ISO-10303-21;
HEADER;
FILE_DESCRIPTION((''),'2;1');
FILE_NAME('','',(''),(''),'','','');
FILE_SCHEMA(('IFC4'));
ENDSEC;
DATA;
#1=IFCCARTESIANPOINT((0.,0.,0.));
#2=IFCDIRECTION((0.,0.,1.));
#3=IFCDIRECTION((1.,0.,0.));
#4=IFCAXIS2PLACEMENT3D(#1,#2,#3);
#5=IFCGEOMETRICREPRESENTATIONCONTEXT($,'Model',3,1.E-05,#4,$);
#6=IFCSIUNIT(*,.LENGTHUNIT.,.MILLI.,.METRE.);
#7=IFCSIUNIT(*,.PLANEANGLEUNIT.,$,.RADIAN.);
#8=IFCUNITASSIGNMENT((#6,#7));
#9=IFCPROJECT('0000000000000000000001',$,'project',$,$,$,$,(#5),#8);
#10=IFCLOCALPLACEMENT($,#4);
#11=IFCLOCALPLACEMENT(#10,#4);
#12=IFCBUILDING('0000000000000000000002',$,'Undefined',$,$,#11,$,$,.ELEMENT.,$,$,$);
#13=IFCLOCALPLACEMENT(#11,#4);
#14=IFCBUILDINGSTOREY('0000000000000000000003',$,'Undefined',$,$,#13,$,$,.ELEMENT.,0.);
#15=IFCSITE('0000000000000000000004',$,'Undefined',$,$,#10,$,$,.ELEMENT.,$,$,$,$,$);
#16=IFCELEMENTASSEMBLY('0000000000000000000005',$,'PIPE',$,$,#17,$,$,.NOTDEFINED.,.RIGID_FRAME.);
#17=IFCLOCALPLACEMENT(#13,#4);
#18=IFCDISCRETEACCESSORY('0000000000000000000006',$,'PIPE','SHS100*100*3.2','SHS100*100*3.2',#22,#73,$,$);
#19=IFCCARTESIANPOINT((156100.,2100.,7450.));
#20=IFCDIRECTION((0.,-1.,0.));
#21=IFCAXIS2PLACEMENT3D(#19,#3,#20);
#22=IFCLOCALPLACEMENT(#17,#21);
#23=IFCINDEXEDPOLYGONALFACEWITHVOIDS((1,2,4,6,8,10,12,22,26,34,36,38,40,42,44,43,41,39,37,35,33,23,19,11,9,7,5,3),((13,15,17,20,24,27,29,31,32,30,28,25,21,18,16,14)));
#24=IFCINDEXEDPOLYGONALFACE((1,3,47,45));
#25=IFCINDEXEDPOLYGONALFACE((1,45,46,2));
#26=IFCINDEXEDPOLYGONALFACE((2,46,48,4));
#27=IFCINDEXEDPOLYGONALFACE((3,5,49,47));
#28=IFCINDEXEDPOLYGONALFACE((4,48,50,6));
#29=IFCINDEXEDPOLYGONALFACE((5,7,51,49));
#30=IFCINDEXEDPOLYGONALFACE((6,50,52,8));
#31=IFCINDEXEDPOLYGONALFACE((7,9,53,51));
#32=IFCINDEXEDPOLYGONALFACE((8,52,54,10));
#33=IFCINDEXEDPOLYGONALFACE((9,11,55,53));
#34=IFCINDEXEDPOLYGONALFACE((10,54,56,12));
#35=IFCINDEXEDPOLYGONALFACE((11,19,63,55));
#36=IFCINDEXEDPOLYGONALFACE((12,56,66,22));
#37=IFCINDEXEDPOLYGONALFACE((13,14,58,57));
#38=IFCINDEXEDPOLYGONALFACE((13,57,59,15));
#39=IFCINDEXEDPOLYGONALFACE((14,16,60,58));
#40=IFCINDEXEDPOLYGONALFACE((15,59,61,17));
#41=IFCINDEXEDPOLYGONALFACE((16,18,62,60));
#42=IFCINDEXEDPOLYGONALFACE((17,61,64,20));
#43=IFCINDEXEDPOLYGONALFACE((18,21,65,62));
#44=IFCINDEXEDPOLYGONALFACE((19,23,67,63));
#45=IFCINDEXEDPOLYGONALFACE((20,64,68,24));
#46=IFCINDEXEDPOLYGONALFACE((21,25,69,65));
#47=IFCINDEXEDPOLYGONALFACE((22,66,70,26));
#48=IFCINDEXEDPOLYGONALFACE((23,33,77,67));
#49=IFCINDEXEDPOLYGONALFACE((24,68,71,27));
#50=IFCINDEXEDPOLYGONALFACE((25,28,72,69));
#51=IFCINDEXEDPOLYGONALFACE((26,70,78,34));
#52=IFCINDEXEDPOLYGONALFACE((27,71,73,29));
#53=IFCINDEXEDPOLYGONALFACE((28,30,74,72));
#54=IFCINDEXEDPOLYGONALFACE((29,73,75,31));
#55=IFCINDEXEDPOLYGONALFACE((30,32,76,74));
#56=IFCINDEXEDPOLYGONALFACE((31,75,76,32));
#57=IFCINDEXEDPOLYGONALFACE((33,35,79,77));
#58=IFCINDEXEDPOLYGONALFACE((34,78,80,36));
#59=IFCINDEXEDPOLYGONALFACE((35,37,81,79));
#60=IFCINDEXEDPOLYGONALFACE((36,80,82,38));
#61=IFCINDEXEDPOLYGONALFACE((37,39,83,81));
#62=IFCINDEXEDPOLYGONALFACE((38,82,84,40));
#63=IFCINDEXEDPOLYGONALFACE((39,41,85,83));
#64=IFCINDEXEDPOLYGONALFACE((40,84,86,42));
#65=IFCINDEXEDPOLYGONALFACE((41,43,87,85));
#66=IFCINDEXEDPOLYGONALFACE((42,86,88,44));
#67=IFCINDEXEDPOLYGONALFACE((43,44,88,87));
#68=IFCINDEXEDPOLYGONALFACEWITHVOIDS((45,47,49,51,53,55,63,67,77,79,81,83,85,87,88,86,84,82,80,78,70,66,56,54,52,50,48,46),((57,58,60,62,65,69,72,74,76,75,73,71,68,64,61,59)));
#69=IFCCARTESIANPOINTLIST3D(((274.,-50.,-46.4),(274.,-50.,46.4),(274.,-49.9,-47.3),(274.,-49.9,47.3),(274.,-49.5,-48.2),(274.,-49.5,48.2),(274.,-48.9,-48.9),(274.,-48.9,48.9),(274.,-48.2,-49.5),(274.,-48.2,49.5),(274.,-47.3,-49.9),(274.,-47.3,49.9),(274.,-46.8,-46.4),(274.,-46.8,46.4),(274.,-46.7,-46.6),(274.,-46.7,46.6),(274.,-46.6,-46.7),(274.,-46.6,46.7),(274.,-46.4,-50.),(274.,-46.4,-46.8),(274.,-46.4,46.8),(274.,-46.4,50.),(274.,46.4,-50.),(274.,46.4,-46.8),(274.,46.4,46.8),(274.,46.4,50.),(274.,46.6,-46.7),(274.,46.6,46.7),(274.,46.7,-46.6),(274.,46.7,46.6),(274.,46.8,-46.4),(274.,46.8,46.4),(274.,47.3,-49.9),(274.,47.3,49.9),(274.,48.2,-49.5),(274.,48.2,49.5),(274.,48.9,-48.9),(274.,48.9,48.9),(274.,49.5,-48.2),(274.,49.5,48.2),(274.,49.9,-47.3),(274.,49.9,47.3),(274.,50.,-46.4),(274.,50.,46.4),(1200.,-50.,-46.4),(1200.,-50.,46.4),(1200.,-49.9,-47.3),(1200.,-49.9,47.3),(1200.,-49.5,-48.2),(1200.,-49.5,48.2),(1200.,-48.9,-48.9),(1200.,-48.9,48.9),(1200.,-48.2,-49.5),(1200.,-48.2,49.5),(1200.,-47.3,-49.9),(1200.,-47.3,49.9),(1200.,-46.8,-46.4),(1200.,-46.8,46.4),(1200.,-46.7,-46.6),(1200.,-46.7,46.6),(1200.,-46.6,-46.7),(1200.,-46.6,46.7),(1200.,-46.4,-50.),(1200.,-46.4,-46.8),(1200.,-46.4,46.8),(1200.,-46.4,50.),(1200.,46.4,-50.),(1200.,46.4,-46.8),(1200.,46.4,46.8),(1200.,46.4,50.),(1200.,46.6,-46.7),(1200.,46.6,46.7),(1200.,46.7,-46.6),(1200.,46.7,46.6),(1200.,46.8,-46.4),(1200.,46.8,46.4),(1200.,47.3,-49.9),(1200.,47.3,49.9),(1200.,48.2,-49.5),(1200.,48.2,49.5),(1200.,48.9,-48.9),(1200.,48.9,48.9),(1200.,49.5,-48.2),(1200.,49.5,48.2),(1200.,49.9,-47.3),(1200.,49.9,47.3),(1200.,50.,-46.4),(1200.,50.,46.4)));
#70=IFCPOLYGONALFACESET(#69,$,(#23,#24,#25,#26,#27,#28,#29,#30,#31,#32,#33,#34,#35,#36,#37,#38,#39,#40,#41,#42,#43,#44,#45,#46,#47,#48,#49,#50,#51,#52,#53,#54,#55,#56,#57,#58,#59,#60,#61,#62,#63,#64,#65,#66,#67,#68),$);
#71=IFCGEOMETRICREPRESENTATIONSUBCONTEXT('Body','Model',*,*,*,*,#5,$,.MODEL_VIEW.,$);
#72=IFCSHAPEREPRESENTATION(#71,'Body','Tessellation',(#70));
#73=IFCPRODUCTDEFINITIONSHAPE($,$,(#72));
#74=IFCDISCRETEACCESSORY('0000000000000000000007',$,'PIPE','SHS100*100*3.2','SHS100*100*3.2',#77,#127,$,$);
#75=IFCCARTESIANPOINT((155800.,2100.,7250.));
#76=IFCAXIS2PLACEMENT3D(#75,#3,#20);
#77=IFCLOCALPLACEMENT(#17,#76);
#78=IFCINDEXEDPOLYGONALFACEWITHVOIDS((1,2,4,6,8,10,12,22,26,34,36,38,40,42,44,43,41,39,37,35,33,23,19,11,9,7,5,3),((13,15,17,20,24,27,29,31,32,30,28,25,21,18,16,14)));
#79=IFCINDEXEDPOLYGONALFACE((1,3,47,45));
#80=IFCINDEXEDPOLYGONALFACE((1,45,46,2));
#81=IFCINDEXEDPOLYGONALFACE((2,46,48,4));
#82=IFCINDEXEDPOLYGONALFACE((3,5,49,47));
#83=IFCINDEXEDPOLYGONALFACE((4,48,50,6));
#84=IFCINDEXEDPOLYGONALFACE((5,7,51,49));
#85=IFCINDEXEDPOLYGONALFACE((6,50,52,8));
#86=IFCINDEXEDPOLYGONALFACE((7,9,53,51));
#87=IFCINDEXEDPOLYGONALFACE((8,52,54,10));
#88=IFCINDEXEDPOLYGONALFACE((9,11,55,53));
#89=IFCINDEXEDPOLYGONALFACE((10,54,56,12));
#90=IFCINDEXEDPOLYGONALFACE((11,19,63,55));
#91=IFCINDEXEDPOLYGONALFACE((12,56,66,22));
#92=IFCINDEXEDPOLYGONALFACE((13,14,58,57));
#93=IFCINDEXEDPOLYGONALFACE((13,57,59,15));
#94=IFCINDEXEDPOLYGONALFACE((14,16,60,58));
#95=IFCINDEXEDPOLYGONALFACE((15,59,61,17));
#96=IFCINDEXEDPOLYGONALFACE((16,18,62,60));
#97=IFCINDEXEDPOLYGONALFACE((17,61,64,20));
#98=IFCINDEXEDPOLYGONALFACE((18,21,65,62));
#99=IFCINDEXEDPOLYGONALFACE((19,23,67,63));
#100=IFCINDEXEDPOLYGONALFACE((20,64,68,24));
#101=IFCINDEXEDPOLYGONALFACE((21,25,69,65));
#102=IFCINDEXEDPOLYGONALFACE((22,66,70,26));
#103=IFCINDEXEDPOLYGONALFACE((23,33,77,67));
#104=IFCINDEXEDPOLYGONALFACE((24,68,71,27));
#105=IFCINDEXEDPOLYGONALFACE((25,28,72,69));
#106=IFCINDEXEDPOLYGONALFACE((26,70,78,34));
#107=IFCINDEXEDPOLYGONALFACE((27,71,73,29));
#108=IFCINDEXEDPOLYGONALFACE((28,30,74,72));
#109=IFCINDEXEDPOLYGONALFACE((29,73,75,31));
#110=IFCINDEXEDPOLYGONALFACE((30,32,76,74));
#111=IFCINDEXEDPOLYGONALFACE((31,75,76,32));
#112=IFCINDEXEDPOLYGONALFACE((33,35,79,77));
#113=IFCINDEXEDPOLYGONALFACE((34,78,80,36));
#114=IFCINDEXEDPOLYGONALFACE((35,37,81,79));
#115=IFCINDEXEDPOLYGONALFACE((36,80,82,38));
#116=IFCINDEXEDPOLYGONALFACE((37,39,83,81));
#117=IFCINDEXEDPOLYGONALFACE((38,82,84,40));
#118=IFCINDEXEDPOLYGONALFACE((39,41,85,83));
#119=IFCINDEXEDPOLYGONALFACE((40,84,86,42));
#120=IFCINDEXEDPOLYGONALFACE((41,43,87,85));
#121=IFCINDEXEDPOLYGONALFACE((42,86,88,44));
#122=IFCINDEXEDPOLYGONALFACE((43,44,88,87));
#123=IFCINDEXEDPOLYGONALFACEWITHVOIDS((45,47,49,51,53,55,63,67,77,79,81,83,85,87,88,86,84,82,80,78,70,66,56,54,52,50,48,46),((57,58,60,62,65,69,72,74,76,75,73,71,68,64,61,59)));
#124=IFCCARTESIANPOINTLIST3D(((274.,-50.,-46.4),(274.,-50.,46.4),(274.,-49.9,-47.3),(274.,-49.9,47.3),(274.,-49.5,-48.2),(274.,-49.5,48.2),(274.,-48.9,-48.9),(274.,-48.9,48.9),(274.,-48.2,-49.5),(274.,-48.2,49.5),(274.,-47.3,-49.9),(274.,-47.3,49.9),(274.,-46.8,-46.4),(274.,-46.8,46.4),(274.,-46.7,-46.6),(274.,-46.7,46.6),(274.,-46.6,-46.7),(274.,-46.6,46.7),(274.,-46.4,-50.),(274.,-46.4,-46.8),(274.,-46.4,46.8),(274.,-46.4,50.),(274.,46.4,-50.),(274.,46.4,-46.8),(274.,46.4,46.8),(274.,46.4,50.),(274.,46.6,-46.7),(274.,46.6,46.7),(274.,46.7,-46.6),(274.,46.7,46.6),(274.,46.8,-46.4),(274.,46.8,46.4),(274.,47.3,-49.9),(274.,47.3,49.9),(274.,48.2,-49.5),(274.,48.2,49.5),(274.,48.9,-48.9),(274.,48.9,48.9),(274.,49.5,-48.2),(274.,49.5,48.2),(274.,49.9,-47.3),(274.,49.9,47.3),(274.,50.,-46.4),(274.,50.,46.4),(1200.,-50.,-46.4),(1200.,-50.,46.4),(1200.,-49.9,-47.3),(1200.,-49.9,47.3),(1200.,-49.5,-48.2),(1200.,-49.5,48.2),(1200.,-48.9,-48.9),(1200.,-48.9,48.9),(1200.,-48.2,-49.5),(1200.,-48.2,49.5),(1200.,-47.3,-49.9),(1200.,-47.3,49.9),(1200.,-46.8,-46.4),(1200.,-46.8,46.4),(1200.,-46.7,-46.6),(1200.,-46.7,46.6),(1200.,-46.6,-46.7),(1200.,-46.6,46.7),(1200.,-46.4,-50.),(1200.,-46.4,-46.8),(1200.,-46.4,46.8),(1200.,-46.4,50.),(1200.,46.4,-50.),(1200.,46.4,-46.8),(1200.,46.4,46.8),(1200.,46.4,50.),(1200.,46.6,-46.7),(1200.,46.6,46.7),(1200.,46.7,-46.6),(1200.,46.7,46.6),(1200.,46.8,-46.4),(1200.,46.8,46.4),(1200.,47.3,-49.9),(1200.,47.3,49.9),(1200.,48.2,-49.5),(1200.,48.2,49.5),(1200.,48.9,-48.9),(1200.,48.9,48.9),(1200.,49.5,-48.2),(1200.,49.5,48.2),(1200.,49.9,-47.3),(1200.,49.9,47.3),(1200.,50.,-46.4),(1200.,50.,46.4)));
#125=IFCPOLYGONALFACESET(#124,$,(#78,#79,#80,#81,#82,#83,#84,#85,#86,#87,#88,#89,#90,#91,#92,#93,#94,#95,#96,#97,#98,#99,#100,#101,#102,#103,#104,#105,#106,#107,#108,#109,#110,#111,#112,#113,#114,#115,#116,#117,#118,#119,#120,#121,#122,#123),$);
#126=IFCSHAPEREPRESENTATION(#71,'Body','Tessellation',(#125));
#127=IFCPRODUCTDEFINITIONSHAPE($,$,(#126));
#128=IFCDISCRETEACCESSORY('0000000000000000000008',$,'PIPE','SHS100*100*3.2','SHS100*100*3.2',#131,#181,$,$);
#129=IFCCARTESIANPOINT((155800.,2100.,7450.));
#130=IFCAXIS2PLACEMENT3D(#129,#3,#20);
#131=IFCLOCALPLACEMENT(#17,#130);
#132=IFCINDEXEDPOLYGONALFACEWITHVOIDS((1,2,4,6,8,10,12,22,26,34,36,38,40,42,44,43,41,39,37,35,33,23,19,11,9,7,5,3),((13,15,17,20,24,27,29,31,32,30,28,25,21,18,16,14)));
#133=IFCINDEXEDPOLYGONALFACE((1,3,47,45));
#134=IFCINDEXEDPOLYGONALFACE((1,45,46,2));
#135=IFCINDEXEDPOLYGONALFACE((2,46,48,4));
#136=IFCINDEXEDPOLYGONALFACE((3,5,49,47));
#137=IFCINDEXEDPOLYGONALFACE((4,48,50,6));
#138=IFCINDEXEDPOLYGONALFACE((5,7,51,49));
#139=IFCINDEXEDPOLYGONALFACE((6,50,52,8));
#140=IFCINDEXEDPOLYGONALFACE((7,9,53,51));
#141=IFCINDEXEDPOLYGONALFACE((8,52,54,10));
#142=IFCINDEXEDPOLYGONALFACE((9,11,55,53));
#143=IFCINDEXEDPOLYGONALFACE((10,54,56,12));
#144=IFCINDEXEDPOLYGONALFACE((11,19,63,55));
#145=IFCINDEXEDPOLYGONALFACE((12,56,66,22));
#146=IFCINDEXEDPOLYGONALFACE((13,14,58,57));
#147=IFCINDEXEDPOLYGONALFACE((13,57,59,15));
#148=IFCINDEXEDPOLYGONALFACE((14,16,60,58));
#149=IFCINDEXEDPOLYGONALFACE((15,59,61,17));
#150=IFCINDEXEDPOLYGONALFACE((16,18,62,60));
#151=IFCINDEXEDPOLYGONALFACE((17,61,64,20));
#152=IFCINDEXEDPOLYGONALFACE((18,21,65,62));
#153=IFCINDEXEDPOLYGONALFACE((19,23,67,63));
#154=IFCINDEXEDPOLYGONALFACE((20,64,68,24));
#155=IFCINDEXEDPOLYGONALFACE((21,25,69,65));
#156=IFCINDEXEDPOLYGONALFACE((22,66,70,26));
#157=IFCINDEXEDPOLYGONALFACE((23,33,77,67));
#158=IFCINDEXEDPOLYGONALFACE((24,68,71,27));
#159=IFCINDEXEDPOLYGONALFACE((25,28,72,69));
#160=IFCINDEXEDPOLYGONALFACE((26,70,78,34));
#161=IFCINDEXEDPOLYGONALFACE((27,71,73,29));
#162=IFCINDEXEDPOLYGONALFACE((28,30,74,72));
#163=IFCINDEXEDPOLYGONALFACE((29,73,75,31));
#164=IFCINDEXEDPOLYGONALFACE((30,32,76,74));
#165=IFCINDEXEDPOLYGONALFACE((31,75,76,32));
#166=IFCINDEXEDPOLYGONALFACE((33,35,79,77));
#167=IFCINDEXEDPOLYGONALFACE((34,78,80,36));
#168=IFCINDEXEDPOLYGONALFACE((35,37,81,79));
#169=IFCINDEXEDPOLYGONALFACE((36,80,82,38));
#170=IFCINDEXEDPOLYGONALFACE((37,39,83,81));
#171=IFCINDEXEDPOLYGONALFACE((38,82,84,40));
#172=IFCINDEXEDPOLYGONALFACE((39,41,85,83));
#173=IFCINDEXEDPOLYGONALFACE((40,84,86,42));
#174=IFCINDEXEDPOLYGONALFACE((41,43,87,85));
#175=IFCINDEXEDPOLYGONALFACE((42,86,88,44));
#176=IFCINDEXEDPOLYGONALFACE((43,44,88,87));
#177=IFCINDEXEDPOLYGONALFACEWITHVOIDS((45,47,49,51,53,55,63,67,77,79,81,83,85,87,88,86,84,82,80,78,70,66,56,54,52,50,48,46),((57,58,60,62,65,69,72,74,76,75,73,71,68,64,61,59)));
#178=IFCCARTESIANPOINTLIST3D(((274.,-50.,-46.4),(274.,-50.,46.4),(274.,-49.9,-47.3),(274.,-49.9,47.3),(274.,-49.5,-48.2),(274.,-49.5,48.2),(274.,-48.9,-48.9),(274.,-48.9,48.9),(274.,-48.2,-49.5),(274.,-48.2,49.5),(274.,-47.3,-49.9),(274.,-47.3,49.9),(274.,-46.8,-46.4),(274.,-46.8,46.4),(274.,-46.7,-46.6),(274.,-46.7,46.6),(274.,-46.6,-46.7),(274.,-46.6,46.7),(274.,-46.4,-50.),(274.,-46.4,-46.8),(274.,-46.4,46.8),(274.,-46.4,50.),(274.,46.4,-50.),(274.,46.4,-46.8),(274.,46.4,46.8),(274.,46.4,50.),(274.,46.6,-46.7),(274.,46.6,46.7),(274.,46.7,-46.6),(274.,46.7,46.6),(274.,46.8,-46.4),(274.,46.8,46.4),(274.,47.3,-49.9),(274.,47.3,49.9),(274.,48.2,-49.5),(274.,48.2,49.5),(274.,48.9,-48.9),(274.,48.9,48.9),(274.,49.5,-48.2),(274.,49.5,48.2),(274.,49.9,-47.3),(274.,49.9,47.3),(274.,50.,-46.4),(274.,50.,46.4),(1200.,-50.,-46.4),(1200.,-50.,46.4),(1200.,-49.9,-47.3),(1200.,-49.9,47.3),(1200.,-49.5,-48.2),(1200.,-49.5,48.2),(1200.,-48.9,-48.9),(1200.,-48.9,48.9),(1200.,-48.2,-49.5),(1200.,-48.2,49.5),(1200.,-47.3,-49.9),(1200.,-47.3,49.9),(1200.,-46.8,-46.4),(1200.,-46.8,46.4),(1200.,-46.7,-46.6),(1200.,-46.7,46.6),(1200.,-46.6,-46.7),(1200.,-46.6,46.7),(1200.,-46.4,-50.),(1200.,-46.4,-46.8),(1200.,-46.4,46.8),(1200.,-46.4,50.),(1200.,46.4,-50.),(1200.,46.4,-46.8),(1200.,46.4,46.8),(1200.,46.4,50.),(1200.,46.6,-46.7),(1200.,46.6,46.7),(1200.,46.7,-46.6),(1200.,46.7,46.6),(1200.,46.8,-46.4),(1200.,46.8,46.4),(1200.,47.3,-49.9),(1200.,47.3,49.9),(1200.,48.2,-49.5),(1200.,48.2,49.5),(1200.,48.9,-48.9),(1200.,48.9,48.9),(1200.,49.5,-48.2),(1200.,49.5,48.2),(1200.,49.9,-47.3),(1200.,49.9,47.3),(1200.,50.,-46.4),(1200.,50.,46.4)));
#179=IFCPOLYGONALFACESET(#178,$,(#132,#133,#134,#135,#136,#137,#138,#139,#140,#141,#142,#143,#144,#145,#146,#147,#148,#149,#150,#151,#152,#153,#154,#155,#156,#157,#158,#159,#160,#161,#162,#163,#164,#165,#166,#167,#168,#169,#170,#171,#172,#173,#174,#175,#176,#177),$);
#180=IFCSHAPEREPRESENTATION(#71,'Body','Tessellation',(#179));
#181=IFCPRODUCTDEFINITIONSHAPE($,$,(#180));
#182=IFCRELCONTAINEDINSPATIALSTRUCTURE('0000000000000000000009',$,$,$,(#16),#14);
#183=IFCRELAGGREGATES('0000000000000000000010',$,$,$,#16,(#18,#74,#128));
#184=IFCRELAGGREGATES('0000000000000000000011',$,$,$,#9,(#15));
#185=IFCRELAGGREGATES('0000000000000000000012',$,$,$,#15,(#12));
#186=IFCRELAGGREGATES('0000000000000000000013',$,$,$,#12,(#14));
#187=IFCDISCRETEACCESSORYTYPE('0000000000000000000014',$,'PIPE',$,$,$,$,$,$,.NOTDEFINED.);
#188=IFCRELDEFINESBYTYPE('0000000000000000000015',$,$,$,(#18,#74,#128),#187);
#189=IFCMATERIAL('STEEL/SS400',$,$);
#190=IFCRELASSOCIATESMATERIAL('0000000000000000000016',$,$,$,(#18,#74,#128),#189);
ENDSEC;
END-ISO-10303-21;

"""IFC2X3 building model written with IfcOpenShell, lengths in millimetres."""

from ifc_helpers import new_model, si_unit, frame, origin_with_axes, origin_2d_with_axis, place, context, subcontext, project, spatial, hollow_rectangle, extrude, clip, halfspace, material, type_object, element, aggregate, save


model = new_model("IFC2X3")

# Units and contexts
model_context = context("Model", 3, precision=1e-05, world=origin_with_axes())
body_context = subcontext(model_context, "Body", "Model", "MODEL_VIEW")
ifc_project = project(units=[si_unit("LENGTHUNIT", "METRE", prefix="MILLI"), si_unit("PLANEANGLEUNIT", "RADIAN")], contexts=[model_context])

# Site, building, storey
site_placement = place(None, origin_with_axes())
site = spatial("IfcSite", under=ifc_project, at=site_placement, Name="Undefined", CompositionType="ELEMENT")
building_placement = place(site_placement, origin_with_axes())
building = spatial("IfcBuilding", under=site, at=building_placement, Name="Undefined", CompositionType="ELEMENT")
storey_placement = place(building_placement, origin_with_axes())
storey = spatial("IfcBuildingStorey", under=building, at=storey_placement, Name="Undefined", CompositionType="ELEMENT", Elevation=0.0)

# Shared definitions
ifc_material_1 = material(Name="STEEL/SS400")

# Shared definitions
discrete_accessory_type_1 = type_object("IfcDiscreteAccessoryType", Name="PIPE")

# Element assembly, discrete accessories
assembly_1_placement = place(storey_placement, origin_with_axes())
assembly_1 = element("IfcElementAssembly", 1, at=assembly_1_placement, inside=storey, Name="PIPE", AssemblyPlace="NOTDEFINED", PredefinedType="RIGID_FRAME")
discrete_accessory_1_placement = place(assembly_1_placement, frame((156100.0, 2100.0, 7450.0), z_axis=(1.0, 0.0, 0.0), x_axis=(0.0, -1.0, 0.0)))
discrete_accessory_1 = element("IfcDiscreteAccessory", 2, at=discrete_accessory_1_placement, type_object=discrete_accessory_type_1, material=ifc_material_1, Name="PIPE", Description="SHS100*100*3.2", ObjectType="SHS100*100*3.2", context=body_context, shape_type="Clipping", body=[
    clip(clip(extrude(hollow_rectangle(XDim=100.0, YDim=100.0, WallThickness=3.2, InnerFilletRadius=0.4, OuterFilletRadius=3.6, at=origin_2d_with_axis()), frame((1200.0, 0.0, 0.0), z_axis=(-1.0, 0.0, 0.0), x_axis=(0.0, -1.0, 0.0)), (0.0, 0.0, 1.0), 1200.0), halfspace(frame((274.0, 50.0, -50.0), z_axis=(-1.0, 0.0, 0.0), x_axis=(0.0, 0.0, 1.0)), False)), halfspace(frame((1200.0, 0.0, -50.0), z_axis=(-1.0, 0.0, 0.0), x_axis=(0.0, 1.0, 0.0)), True)),
])
discrete_accessory_2_placement = place(assembly_1_placement, frame((155800.0, 2100.0, 7250.0), z_axis=(1.0, 0.0, 0.0), x_axis=(0.0, -1.0, 0.0)))
discrete_accessory_2 = element("IfcDiscreteAccessory", 3, at=discrete_accessory_2_placement, type_object=discrete_accessory_type_1, material=ifc_material_1, Name="PIPE", Description="SHS100*100*3.2", ObjectType="SHS100*100*3.2", context=body_context, shape_type="Clipping", body=[
    clip(clip(extrude(hollow_rectangle(XDim=100.0, YDim=100.0, WallThickness=3.2, InnerFilletRadius=0.4, OuterFilletRadius=3.6, at=origin_2d_with_axis()), frame((1200.0, 0.0, 0.0), z_axis=(-1.0, 0.0, 0.0), x_axis=(0.0, -1.0, 0.0)), (0.0, 0.0, 1.0), 1200.0), halfspace(frame((274.0, 50.0, -50.0), z_axis=(-1.0, 0.0, 0.0), x_axis=(0.0, 0.0, 1.0)), False)), halfspace(frame((1200.0, 0.0, -50.0), z_axis=(-1.0, 0.0, 0.0), x_axis=(0.0, 1.0, 0.0)), True)),
])
discrete_accessory_3_placement = place(assembly_1_placement, frame((155800.0, 2100.0, 7450.0), z_axis=(1.0, 0.0, 0.0), x_axis=(0.0, -1.0, 0.0)))
discrete_accessory_3 = element("IfcDiscreteAccessory", 4, at=discrete_accessory_3_placement, type_object=discrete_accessory_type_1, material=ifc_material_1, Name="PIPE", Description="SHS100*100*3.2", ObjectType="SHS100*100*3.2", context=body_context, shape_type="Clipping", body=[
    clip(clip(extrude(hollow_rectangle(XDim=100.0, YDim=100.0, WallThickness=3.2, InnerFilletRadius=0.4, OuterFilletRadius=3.6, at=origin_2d_with_axis()), frame((1200.0, 0.0, 0.0), z_axis=(-1.0, 0.0, 0.0), x_axis=(0.0, -1.0, 0.0)), (0.0, 0.0, 1.0), 1200.0), halfspace(frame((274.0, 50.0, -50.0), z_axis=(-1.0, 0.0, 0.0), x_axis=(0.0, 0.0, 1.0)), False)), halfspace(frame((1200.0, 0.0, -50.0), z_axis=(-1.0, 0.0, 0.0), x_axis=(0.0, 1.0, 0.0)), True)),
])
aggregate(assembly_1, [discrete_accessory_1, discrete_accessory_2, discrete_accessory_3])

save(model, "model.ifc")
